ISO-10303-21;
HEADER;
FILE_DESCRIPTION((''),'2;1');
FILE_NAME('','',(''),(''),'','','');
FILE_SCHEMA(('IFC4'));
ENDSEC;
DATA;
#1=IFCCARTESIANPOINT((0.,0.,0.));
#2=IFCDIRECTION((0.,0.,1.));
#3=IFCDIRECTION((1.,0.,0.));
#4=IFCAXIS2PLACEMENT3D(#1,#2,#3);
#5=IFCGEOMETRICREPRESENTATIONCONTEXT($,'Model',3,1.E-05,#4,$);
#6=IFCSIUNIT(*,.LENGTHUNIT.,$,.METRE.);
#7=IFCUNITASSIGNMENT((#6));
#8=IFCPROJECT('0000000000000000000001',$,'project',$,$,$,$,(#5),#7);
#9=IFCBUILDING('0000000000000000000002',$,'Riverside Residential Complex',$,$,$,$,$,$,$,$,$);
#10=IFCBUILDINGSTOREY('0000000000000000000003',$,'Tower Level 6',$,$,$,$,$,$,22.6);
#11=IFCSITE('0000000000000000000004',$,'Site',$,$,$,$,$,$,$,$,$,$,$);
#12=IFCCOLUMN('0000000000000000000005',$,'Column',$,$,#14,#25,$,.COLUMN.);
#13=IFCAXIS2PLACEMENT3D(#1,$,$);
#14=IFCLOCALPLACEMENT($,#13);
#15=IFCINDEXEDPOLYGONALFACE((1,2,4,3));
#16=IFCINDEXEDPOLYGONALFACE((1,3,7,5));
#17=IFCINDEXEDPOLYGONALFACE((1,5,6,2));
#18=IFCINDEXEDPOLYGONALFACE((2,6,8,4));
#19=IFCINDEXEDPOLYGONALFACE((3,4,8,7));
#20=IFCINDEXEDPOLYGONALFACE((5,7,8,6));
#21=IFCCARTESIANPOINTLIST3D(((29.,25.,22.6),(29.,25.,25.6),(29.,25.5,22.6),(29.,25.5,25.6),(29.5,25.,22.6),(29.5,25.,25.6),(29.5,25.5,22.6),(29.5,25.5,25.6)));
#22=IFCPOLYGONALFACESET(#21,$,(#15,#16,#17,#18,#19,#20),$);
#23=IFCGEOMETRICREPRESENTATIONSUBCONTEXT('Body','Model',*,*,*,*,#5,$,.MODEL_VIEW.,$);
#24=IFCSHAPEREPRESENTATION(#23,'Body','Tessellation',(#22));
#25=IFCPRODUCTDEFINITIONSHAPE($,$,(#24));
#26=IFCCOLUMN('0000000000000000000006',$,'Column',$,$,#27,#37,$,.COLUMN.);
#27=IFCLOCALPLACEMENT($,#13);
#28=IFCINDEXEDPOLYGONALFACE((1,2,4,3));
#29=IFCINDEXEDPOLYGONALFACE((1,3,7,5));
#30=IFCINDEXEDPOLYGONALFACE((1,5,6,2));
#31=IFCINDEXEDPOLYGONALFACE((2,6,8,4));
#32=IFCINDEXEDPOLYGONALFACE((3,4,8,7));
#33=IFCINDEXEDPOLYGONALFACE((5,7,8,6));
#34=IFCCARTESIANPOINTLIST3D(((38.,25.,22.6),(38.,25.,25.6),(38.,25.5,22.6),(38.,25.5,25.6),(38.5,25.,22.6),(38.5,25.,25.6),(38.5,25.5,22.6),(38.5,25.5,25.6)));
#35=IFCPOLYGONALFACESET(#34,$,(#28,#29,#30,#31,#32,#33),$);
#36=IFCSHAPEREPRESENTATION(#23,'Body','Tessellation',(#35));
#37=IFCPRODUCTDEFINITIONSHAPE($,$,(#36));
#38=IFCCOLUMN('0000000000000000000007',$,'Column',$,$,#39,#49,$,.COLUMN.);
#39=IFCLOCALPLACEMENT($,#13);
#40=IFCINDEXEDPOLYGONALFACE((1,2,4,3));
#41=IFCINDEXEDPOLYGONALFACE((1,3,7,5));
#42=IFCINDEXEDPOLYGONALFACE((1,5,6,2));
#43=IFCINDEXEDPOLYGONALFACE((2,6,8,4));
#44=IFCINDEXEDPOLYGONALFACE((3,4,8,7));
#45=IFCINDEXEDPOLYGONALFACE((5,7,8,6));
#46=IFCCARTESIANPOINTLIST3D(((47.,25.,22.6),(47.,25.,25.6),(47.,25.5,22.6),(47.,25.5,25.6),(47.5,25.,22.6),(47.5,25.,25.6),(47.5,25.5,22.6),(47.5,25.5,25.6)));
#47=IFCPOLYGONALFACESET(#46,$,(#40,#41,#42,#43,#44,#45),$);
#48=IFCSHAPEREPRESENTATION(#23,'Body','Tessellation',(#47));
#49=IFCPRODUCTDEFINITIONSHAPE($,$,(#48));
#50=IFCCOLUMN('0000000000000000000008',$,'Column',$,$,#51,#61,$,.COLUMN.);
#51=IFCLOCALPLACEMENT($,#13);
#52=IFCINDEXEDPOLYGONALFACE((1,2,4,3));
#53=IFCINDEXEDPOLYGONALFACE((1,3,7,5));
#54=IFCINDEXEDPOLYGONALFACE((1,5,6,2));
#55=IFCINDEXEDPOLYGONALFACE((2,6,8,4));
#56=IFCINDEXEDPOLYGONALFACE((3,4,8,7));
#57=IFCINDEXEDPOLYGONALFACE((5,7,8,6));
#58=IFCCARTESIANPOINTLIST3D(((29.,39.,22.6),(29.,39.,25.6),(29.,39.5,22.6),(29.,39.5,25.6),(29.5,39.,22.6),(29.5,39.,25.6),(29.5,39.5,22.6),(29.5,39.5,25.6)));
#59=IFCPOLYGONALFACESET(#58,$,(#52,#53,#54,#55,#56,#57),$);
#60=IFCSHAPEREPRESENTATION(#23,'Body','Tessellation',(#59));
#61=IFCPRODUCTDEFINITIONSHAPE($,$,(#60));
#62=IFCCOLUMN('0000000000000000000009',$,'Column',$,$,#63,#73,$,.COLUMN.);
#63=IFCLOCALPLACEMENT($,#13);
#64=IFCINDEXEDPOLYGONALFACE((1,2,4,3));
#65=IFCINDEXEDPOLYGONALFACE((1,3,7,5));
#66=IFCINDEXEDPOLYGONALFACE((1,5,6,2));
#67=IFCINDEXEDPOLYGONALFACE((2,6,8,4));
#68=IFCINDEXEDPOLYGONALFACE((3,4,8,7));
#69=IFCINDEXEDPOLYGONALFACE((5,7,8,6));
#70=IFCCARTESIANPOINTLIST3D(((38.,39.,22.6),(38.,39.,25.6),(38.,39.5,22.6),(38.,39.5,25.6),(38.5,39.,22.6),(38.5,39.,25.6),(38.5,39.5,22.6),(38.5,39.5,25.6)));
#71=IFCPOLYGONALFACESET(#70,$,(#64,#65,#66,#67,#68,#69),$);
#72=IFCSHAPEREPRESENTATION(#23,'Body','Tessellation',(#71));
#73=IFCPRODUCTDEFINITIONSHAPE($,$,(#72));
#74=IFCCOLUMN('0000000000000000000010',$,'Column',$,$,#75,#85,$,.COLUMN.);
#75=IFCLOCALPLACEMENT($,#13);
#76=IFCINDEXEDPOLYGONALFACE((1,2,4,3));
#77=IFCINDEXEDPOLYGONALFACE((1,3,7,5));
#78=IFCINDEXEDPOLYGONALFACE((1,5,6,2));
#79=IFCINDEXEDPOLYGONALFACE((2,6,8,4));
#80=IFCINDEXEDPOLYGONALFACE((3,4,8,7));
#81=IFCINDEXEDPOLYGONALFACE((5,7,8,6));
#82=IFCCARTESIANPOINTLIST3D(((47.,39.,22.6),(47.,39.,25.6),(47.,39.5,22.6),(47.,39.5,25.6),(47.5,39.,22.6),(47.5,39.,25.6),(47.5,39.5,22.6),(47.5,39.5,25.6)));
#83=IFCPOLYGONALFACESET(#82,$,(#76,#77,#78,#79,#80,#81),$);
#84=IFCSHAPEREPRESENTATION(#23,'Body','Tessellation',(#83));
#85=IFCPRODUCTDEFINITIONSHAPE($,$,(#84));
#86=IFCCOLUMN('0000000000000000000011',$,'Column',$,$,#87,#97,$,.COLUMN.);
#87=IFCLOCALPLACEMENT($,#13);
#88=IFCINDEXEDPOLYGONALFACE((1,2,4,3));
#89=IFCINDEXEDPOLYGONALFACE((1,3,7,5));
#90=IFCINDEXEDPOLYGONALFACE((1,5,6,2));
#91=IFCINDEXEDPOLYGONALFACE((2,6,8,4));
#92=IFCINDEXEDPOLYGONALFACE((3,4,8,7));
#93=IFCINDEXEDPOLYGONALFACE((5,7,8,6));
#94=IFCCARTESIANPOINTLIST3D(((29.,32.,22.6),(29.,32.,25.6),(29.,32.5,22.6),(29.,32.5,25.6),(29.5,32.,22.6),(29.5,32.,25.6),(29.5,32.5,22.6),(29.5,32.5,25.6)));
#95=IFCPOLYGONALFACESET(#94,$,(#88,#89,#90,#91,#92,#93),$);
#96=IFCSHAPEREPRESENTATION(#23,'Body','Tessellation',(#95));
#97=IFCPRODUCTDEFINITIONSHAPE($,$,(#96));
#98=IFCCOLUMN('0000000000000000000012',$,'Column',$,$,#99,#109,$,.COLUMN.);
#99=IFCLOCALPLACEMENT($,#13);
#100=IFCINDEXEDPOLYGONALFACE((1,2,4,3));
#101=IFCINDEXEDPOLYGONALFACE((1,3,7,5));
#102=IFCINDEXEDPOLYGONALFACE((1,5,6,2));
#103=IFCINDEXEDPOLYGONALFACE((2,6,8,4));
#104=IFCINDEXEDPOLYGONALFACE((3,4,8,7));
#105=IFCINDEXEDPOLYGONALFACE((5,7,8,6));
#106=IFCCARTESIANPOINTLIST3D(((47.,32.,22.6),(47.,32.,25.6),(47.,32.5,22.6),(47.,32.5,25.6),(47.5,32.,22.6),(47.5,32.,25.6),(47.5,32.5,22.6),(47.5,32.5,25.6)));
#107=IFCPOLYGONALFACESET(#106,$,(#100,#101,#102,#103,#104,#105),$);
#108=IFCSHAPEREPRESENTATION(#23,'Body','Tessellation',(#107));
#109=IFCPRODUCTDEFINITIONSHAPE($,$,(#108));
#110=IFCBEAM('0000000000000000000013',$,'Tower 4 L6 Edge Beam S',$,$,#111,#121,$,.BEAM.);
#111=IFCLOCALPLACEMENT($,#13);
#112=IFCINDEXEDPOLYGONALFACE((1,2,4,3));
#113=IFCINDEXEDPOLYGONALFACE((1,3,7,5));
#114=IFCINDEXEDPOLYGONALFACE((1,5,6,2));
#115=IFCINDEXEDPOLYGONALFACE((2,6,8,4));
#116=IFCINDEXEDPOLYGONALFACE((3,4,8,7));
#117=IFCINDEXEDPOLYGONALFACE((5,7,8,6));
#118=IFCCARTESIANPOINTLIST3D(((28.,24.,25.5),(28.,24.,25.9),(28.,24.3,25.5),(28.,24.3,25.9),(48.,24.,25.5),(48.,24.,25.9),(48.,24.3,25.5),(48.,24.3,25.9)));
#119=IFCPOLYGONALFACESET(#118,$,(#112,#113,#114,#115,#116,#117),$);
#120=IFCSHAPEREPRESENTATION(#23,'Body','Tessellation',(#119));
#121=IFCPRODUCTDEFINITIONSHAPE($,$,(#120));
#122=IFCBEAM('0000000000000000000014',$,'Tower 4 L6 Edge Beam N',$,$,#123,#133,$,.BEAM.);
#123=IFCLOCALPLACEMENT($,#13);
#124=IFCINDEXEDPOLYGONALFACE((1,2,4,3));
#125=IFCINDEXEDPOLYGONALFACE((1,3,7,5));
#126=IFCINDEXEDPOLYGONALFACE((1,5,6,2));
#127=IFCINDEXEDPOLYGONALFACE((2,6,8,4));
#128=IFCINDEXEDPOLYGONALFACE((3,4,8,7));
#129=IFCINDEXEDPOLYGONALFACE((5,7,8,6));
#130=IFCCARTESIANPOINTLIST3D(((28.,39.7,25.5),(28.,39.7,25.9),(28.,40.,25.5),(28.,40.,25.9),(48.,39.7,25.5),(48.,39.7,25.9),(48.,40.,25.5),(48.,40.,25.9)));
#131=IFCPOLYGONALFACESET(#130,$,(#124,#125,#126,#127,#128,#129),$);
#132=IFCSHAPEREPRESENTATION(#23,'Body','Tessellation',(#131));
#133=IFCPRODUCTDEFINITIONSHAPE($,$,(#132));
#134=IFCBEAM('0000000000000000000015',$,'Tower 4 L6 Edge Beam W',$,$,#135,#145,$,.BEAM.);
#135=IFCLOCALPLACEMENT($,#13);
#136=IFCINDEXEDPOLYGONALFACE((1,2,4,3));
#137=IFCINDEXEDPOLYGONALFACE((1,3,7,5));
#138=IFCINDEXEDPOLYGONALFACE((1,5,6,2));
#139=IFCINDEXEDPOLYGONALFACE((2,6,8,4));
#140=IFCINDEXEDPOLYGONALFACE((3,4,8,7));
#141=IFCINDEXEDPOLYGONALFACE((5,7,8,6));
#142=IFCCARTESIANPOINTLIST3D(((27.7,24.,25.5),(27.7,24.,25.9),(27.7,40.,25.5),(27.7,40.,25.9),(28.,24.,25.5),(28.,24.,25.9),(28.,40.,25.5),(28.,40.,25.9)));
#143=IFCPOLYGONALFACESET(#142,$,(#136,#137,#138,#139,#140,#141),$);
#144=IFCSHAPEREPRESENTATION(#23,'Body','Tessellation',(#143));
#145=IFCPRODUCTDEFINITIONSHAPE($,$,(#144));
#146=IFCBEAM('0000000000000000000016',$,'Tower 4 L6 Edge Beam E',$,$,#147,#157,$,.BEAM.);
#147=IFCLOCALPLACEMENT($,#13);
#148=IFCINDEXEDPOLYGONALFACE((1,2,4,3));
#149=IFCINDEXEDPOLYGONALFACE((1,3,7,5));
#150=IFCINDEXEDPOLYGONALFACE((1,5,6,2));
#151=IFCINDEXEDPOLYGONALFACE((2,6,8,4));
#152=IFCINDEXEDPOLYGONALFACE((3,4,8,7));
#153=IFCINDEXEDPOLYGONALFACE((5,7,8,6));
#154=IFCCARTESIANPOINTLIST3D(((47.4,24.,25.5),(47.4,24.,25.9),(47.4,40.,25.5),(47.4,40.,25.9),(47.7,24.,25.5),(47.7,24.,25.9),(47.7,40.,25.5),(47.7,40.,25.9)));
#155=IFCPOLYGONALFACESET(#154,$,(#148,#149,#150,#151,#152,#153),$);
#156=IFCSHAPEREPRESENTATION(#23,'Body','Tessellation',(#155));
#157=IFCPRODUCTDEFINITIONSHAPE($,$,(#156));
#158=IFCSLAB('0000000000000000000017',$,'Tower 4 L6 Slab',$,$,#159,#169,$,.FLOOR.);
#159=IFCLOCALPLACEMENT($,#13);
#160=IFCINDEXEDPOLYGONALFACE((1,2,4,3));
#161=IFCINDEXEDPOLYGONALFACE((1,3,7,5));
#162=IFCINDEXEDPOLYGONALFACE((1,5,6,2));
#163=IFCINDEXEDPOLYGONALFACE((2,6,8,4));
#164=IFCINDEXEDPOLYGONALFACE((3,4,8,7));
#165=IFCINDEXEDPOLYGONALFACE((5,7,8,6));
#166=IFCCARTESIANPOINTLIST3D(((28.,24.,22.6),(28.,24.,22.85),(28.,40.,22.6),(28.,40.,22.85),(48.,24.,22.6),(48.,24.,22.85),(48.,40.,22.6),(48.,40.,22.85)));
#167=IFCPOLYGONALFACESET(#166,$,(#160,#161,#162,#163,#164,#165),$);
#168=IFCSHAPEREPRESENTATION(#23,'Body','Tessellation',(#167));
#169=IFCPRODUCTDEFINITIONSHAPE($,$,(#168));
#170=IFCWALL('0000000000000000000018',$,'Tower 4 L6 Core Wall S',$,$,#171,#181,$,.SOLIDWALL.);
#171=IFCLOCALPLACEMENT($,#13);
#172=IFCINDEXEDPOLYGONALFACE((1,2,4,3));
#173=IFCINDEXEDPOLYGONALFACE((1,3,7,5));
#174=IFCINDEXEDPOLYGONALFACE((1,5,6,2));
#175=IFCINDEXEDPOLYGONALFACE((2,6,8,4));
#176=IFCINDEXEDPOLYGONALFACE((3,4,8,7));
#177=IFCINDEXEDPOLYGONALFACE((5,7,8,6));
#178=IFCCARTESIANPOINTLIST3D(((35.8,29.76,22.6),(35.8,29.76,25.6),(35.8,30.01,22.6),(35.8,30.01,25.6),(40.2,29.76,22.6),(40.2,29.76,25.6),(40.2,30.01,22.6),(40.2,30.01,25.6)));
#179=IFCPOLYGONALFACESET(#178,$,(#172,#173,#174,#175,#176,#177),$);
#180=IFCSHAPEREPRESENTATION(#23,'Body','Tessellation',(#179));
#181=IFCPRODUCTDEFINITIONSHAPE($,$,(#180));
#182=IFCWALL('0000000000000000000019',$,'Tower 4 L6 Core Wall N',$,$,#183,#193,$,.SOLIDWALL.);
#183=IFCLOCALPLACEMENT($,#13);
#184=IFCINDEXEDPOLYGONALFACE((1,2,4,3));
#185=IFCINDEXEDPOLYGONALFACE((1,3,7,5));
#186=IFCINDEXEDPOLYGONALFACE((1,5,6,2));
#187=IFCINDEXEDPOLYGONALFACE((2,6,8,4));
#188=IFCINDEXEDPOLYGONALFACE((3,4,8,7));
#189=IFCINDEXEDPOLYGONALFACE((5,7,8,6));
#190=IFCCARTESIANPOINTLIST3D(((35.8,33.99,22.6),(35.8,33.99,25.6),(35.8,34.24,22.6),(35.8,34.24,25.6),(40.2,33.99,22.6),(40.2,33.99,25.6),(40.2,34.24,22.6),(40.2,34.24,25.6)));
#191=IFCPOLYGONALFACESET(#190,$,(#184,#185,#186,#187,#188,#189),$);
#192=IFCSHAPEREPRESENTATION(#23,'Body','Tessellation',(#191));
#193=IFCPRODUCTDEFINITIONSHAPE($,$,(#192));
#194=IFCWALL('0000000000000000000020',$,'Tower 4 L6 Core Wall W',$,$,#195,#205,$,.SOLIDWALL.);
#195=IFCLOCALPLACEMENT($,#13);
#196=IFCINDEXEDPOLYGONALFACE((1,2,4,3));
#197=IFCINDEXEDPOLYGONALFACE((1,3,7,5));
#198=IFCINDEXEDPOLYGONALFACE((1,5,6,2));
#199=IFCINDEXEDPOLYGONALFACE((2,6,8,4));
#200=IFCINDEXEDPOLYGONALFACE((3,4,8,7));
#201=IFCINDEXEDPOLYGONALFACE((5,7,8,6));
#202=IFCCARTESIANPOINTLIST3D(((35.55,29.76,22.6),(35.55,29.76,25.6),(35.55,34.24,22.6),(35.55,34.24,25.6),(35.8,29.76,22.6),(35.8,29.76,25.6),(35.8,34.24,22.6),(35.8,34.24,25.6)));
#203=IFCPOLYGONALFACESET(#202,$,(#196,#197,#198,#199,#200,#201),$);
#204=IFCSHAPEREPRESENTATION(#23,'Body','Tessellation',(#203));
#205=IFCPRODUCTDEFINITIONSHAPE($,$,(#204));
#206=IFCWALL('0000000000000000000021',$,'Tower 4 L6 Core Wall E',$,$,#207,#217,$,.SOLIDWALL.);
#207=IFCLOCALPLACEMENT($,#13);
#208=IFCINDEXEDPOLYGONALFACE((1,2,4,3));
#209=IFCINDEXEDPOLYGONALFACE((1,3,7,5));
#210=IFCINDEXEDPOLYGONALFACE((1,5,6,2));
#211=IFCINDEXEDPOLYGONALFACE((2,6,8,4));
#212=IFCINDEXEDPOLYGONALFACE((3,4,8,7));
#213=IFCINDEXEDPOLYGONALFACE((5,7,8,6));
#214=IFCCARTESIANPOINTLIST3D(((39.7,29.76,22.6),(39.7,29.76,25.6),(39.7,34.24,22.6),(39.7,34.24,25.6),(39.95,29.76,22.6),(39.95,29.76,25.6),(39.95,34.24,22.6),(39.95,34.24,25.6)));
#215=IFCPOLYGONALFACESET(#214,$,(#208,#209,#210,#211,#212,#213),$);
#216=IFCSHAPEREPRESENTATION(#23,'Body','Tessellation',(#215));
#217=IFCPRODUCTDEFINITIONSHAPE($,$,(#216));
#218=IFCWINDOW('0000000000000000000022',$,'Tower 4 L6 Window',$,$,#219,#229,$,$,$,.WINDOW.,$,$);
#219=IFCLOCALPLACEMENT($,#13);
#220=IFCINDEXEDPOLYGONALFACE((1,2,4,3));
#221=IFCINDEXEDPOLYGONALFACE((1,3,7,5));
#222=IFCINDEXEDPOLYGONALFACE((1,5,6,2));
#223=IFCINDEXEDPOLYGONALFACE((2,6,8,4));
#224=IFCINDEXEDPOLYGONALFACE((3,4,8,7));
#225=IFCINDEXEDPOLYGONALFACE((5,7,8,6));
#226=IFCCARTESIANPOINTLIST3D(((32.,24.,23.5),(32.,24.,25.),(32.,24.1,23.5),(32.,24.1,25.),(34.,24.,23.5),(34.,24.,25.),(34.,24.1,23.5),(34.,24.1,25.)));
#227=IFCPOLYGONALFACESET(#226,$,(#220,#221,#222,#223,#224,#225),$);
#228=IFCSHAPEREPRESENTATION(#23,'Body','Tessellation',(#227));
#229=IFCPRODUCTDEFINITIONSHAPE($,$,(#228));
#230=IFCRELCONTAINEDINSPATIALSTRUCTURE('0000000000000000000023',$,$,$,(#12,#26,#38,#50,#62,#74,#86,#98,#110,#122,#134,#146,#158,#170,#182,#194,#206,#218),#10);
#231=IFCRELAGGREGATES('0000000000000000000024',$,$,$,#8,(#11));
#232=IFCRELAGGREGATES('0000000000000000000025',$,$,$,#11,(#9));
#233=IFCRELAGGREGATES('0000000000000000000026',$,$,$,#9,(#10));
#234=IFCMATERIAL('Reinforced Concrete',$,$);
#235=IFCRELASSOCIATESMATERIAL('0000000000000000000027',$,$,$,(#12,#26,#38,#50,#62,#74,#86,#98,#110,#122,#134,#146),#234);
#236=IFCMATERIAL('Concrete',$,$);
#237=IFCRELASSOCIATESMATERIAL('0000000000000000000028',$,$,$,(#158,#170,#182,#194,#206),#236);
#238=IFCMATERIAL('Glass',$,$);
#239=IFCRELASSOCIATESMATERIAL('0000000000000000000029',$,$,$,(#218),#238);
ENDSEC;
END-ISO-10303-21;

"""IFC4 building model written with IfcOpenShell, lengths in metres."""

from ifc_helpers import new_model, si_unit, frame, origin_with_axes, place, context, subcontext, project, spatial, line, indexed_curve, outline, extrude, material, element, save


model = new_model("IFC4")

# Units and contexts
model_context = context("Model", 3, precision=1e-05, world=origin_with_axes())
body_context = subcontext(model_context, "Body", "Model", "MODEL_VIEW")
ifc_project = project(units=[si_unit("LENGTHUNIT", "METRE")], contexts=[model_context])

# Site, building, storey
site = spatial("IfcSite", under=ifc_project, Name="Site")
building = spatial("IfcBuilding", under=site, Name="Riverside Residential Complex")
storey = spatial("IfcBuildingStorey", under=building, Name="Tower Level 6", Elevation=22.6)

# Columns
ifc_material_1 = material(Name="Reinforced Concrete")
for number, where, z_axis, x_axis, name in (
    (1, (29.0, 25.0, 22.6), (0.0, 0.0, 1.0), (1.0, 0.0, 0.0), "Column"),
    (2, (38.0, 25.0, 22.6), (0.0, 0.0, 1.0), (1.0, 0.0, 0.0), "Column"),
    (3, (47.0, 25.0, 22.6), (0.0, 0.0, 1.0), (1.0, 0.0, 0.0), "Column"),
    (4, (29.0, 39.0, 22.6), (0.0, 0.0, 1.0), (1.0, 0.0, 0.0), "Column"),
    (5, (38.0, 39.0, 22.6), (0.0, 0.0, 1.0), (1.0, 0.0, 0.0), "Column"),
    (6, (47.0, 39.0, 22.6), (0.0, 0.0, 1.0), (1.0, 0.0, 0.0), "Column"),
    (7, (29.0, 32.0, 22.6), (0.0, 0.0, 1.0), (1.0, 0.0, 0.0), "Column"),
    (8, (47.0, 32.0, 22.6), (0.0, 0.0, 1.0), (1.0, 0.0, 0.0), "Column"),
):
    element("IfcColumn", number, at=place(None, frame(where, z_axis=z_axis, x_axis=x_axis)), inside=storey, material=ifc_material_1, Name=name, PredefinedType="COLUMN", context=body_context, shape_type="SweptSolid", body=[
        extrude(outline(indexed_curve([(0.0, 0.0), (0.5, 0.0), (0.5, 0.5), (0.0, 0.5)], segments=[line(1, 2, 3, 4, 1)])), origin_with_axes(), (0.0, 0.0, 1.0), 3.0),
    ])

# Beams
for number, where, z_axis, x_axis, name in (
    (9, (28.0, 24.0, 25.5), (0.0, 0.0, 1.0), (1.0, 0.0, 0.0), "Tower 4 L6 Edge Beam S"),
    (10, (28.0, 39.7, 25.5), (0.0, 0.0, 1.0), (1.0, 0.0, 0.0), "Tower 4 L6 Edge Beam N"),
):
    element("IfcBeam", number, at=place(None, frame(where, z_axis=z_axis, x_axis=x_axis)), inside=storey, material=ifc_material_1, Name=name, PredefinedType="BEAM", context=body_context, shape_type="SweptSolid", body=[
        extrude(outline(indexed_curve([(0.0, 0.0), (20.0, 0.0), (20.0, 0.3), (0.0, 0.3)], segments=[line(1, 2, 3, 4, 1)])), origin_with_axes(), (0.0, 0.0, 1.0), 0.4),
    ])
for number, where, z_axis, x_axis, name in (
    (11, (28.0, 24.0, 25.5), (0.0, 0.0, 1.0), (0.0, 1.0, 0.0), "Tower 4 L6 Edge Beam W"),
    (12, (47.7, 24.0, 25.5), (0.0, 0.0, 1.0), (0.0, 1.0, 0.0), "Tower 4 L6 Edge Beam E"),
):
    element("IfcBeam", number, at=place(None, frame(where, z_axis=z_axis, x_axis=x_axis)), inside=storey, material=ifc_material_1, Name=name, PredefinedType="BEAM", context=body_context, shape_type="SweptSolid", body=[
        extrude(outline(indexed_curve([(0.0, 0.0), (16.0, 0.0), (16.0, 0.3), (0.0, 0.3)], segments=[line(1, 2, 3, 4, 1)])), origin_with_axes(), (0.0, 0.0, 1.0), 0.4),
    ])

# Slab
ifc_material_2 = material(Name="Concrete")
slab_placement = place(None, frame((28.0, 24.0, 22.6), z_axis=(0.0, 0.0, 1.0), x_axis=(1.0, 0.0, 0.0)))
element("IfcSlab", 13, at=slab_placement, inside=storey, material=ifc_material_2, Name="Tower 4 L6 Slab", PredefinedType="FLOOR", context=body_context, shape_type="SweptSolid", body=[
    extrude(outline(indexed_curve([(0.0, 0.0), (20.0, 0.0), (20.0, 16.0), (0.0, 16.0)], segments=[line(1, 2, 3, 4, 1)])), origin_with_axes(), (0.0, 0.0, 1.0), 0.25),
])

# Walls
for number, where, z_axis, x_axis, name in (
    (14, (35.8, 29.76, 22.6), (0.0, 0.0, 1.0), (1.0, 0.0, 0.0), "Tower 4 L6 Core Wall S"),
    (15, (35.8, 33.99, 22.6), (0.0, 0.0, 1.0), (1.0, 0.0, 0.0), "Tower 4 L6 Core Wall N"),
):
    element("IfcWall", number, at=place(None, frame(where, z_axis=z_axis, x_axis=x_axis)), inside=storey, material=ifc_material_2, Name=name, PredefinedType="SOLIDWALL", context=body_context, shape_type="SweptSolid", body=[
        extrude(outline(indexed_curve([(0.0, 0.0), (4.4, 0.0), (4.4, 0.25), (0.0, 0.25)], segments=[line(1, 2, 3, 4, 1)])), origin_with_axes(), (0.0, 0.0, 1.0), 3.0),
    ])
for number, where, z_axis, x_axis, name in (
    (16, (35.8, 29.76, 22.6), (0.0, 0.0, 1.0), (0.0, 1.0, 0.0), "Tower 4 L6 Core Wall W"),
    (17, (39.95, 29.76, 22.6), (0.0, 0.0, 1.0), (0.0, 1.0, 0.0), "Tower 4 L6 Core Wall E"),
):
    element("IfcWall", number, at=place(None, frame(where, z_axis=z_axis, x_axis=x_axis)), inside=storey, material=ifc_material_2, Name=name, PredefinedType="SOLIDWALL", context=body_context, shape_type="SweptSolid", body=[
        extrude(outline(indexed_curve([(0.0, 0.0), (4.48, 0.0), (4.48, 0.25), (0.0, 0.25)], segments=[line(1, 2, 3, 4, 1)])), origin_with_axes(), (0.0, 0.0, 1.0), 3.0),
    ])

# Window
ifc_material_3 = material(Name="Glass")
for number, where, z_axis, x_axis, name in (
    (18, (32.0, 24.0, 23.5), (0.0, 0.0, 1.0), (1.0, 0.0, 0.0), "Tower 4 L6 Window"),
):
    element("IfcWindow", number, at=place(None, frame(where, z_axis=z_axis, x_axis=x_axis)), inside=storey, material=ifc_material_3, Name=name, PredefinedType="WINDOW", context=body_context, shape_type="SweptSolid", body=[
        extrude(outline(indexed_curve([(0.0, 0.0), (2.0, 0.0), (2.0, 0.1), (0.0, 0.1)], segments=[line(1, 2, 3, 4, 1)])), origin_with_axes(), (0.0, 0.0, 1.0), 1.5),
    ])

save(model, "model.ifc")
